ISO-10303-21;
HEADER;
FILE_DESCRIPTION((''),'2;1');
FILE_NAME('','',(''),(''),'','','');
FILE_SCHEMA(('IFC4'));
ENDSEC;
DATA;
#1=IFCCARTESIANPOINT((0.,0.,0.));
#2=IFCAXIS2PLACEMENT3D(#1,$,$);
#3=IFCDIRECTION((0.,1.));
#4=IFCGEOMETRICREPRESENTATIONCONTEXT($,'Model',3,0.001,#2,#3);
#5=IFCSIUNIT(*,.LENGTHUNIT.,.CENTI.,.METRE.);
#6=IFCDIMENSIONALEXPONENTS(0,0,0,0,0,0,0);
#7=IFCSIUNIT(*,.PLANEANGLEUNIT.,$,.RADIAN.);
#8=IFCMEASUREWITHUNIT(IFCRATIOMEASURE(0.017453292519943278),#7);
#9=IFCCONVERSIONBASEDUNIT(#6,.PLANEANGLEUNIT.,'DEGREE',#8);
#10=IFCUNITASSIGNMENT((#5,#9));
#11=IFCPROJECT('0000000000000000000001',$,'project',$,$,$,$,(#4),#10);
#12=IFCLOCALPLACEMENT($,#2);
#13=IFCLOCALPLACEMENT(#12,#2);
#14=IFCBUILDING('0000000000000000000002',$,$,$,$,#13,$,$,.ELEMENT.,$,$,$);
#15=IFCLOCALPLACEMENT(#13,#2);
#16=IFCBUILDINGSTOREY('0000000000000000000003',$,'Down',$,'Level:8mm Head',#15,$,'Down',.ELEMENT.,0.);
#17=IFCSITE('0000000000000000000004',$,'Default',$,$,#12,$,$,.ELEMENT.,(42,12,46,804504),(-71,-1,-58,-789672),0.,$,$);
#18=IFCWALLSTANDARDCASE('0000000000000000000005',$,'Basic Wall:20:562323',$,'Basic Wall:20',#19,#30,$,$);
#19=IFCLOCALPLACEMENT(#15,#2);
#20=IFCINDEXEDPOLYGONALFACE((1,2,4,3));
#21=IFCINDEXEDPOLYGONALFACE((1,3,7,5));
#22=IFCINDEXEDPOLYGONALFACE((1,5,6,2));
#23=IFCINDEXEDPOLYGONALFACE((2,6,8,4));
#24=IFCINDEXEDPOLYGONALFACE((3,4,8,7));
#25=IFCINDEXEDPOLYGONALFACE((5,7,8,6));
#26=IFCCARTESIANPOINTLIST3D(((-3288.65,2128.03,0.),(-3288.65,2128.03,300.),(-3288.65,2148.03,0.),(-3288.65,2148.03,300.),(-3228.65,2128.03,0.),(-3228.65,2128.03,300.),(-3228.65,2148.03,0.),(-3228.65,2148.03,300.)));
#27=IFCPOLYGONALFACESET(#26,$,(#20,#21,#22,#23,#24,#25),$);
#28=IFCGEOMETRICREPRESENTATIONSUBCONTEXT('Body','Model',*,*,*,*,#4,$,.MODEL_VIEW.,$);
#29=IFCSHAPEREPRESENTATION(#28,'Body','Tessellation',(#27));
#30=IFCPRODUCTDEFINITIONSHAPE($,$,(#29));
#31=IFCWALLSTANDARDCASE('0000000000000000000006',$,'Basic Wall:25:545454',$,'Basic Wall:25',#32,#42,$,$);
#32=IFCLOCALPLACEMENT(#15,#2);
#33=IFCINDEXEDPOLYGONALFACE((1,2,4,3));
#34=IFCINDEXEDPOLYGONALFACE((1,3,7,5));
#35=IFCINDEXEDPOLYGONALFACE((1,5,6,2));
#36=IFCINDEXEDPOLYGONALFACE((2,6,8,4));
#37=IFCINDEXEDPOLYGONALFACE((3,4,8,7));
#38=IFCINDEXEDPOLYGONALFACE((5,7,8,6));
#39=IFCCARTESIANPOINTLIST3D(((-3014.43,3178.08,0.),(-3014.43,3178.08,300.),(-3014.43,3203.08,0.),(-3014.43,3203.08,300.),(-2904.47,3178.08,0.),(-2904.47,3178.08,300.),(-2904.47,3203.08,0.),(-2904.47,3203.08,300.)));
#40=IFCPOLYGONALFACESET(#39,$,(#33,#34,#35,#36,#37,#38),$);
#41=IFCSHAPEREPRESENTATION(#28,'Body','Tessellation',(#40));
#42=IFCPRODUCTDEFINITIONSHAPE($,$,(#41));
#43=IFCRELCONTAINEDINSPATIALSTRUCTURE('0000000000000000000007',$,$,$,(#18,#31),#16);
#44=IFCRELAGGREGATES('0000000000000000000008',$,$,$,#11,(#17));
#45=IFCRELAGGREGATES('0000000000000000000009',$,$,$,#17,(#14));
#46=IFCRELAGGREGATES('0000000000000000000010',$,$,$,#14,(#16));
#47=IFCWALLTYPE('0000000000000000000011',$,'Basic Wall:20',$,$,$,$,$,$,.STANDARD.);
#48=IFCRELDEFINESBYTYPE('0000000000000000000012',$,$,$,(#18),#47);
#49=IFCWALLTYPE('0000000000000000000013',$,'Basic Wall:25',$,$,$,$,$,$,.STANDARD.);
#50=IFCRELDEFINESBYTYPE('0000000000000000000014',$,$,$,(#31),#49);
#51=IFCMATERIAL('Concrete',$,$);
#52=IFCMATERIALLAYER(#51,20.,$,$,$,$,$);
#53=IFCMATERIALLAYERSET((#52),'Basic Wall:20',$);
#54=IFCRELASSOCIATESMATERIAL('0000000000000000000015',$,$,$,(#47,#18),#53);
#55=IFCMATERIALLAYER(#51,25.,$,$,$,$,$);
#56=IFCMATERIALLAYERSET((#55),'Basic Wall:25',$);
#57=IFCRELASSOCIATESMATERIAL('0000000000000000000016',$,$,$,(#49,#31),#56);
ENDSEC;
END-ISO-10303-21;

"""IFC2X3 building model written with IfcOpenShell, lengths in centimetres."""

from ifc_helpers import new_model, entity, si_unit, converted_unit, direction, frame, frame_2d, origin, place, context, subcontext, project, spatial, rectangle, extrude, material, layer, layer_set, layer_usage, type_object, element, save


model = new_model("IFC2X3")

# Units and contexts
model_context = context("Model", 3, precision=0.001, world=origin(), true_north=direction((0.0, 1.0)))
body_context = subcontext(model_context, "Body", "Model", "MODEL_VIEW")
ifc_project = project(units=[si_unit("LENGTHUNIT", "METRE", prefix="CENTI"), converted_unit("PLANEANGLEUNIT", "DEGREE", entity("IfcRatioMeasure", 0.017453292519943278), si_unit("PLANEANGLEUNIT", "RADIAN"), dimensions=[0, 0, 0, 0, 0, 0, 0])], contexts=[model_context])

# Site, building, storey
site_placement = place(None, origin())
site = spatial("IfcSite", under=ifc_project, at=site_placement, Name="Default", CompositionType="ELEMENT", RefLatitude=(42, 12, 46, 804504), RefLongitude=(-71, -1, -58, -789672), RefElevation=0.0)
building_placement = place(site_placement, origin())
building = spatial("IfcBuilding", under=site, at=building_placement, CompositionType="ELEMENT")
storey_placement = place(building_placement, origin())
storey = spatial("IfcBuildingStorey", under=building, at=storey_placement, Name="Down", ObjectType="Level:8mm Head", LongName="Down", CompositionType="ELEMENT", Elevation=0.0)

# Shared definitions
ifc_material = material(Name="Concrete")

# Walls
ifc_layer_1 = layer(ifc_material, 20.0)
ifc_layer_set_1 = layer_set([ifc_layer_1], Name="Basic Wall:20")
wall_type_1 = type_object("IfcWallType", Name="Basic Wall:20", PredefinedType="STANDARD", material=ifc_layer_set_1)
ifc_layer_usage_1 = layer_usage(ifc_layer_set_1, "AXIS2", "NEGATIVE", 10.0)
wall_1_placement = place(storey_placement, frame((-3288.65, 2138.03, 0.0)))
element("IfcWallStandardCase", 1, at=wall_1_placement, inside=storey, type_object=wall_type_1, material=ifc_layer_usage_1, Name="Basic Wall:20:562323", ObjectType="Basic Wall:20", context=body_context, shape_type="SweptSolid", body=[
    extrude(rectangle(XDim=60.0, YDim=20.0, at=frame_2d((30.0, 0.0), x_axis=(-1.0, 0.0))), origin(), (0.0, 0.0, 1.0), 300.0),
])
ifc_layer_2 = layer(ifc_material, 25.0)
ifc_layer_set_2 = layer_set([ifc_layer_2], Name="Basic Wall:25")
ifc_layer_usage_2 = layer_usage(ifc_layer_set_2, "AXIS2", "NEGATIVE", 12.5)
wall_type_2 = type_object("IfcWallType", Name="Basic Wall:25", PredefinedType="STANDARD", material=ifc_layer_set_2)
wall_2_placement = place(storey_placement, frame((-2904.47, 3190.58, 0.0), z_axis=(0.0, 0.0, 1.0), x_axis=(-1.0, 0.0, 0.0)))
element("IfcWallStandardCase", 2, at=wall_2_placement, inside=storey, type_object=wall_type_2, material=ifc_layer_usage_2, Name="Basic Wall:25:545454", ObjectType="Basic Wall:25", context=body_context, shape_type="SweptSolid", body=[
    extrude(rectangle(XDim=109.96, YDim=25.0, at=frame_2d((54.98, 0.0), x_axis=(-1.0, 0.0))), origin(), (0.0, 0.0, 1.0), 300.0),
])

save(model, "model.ifc")
